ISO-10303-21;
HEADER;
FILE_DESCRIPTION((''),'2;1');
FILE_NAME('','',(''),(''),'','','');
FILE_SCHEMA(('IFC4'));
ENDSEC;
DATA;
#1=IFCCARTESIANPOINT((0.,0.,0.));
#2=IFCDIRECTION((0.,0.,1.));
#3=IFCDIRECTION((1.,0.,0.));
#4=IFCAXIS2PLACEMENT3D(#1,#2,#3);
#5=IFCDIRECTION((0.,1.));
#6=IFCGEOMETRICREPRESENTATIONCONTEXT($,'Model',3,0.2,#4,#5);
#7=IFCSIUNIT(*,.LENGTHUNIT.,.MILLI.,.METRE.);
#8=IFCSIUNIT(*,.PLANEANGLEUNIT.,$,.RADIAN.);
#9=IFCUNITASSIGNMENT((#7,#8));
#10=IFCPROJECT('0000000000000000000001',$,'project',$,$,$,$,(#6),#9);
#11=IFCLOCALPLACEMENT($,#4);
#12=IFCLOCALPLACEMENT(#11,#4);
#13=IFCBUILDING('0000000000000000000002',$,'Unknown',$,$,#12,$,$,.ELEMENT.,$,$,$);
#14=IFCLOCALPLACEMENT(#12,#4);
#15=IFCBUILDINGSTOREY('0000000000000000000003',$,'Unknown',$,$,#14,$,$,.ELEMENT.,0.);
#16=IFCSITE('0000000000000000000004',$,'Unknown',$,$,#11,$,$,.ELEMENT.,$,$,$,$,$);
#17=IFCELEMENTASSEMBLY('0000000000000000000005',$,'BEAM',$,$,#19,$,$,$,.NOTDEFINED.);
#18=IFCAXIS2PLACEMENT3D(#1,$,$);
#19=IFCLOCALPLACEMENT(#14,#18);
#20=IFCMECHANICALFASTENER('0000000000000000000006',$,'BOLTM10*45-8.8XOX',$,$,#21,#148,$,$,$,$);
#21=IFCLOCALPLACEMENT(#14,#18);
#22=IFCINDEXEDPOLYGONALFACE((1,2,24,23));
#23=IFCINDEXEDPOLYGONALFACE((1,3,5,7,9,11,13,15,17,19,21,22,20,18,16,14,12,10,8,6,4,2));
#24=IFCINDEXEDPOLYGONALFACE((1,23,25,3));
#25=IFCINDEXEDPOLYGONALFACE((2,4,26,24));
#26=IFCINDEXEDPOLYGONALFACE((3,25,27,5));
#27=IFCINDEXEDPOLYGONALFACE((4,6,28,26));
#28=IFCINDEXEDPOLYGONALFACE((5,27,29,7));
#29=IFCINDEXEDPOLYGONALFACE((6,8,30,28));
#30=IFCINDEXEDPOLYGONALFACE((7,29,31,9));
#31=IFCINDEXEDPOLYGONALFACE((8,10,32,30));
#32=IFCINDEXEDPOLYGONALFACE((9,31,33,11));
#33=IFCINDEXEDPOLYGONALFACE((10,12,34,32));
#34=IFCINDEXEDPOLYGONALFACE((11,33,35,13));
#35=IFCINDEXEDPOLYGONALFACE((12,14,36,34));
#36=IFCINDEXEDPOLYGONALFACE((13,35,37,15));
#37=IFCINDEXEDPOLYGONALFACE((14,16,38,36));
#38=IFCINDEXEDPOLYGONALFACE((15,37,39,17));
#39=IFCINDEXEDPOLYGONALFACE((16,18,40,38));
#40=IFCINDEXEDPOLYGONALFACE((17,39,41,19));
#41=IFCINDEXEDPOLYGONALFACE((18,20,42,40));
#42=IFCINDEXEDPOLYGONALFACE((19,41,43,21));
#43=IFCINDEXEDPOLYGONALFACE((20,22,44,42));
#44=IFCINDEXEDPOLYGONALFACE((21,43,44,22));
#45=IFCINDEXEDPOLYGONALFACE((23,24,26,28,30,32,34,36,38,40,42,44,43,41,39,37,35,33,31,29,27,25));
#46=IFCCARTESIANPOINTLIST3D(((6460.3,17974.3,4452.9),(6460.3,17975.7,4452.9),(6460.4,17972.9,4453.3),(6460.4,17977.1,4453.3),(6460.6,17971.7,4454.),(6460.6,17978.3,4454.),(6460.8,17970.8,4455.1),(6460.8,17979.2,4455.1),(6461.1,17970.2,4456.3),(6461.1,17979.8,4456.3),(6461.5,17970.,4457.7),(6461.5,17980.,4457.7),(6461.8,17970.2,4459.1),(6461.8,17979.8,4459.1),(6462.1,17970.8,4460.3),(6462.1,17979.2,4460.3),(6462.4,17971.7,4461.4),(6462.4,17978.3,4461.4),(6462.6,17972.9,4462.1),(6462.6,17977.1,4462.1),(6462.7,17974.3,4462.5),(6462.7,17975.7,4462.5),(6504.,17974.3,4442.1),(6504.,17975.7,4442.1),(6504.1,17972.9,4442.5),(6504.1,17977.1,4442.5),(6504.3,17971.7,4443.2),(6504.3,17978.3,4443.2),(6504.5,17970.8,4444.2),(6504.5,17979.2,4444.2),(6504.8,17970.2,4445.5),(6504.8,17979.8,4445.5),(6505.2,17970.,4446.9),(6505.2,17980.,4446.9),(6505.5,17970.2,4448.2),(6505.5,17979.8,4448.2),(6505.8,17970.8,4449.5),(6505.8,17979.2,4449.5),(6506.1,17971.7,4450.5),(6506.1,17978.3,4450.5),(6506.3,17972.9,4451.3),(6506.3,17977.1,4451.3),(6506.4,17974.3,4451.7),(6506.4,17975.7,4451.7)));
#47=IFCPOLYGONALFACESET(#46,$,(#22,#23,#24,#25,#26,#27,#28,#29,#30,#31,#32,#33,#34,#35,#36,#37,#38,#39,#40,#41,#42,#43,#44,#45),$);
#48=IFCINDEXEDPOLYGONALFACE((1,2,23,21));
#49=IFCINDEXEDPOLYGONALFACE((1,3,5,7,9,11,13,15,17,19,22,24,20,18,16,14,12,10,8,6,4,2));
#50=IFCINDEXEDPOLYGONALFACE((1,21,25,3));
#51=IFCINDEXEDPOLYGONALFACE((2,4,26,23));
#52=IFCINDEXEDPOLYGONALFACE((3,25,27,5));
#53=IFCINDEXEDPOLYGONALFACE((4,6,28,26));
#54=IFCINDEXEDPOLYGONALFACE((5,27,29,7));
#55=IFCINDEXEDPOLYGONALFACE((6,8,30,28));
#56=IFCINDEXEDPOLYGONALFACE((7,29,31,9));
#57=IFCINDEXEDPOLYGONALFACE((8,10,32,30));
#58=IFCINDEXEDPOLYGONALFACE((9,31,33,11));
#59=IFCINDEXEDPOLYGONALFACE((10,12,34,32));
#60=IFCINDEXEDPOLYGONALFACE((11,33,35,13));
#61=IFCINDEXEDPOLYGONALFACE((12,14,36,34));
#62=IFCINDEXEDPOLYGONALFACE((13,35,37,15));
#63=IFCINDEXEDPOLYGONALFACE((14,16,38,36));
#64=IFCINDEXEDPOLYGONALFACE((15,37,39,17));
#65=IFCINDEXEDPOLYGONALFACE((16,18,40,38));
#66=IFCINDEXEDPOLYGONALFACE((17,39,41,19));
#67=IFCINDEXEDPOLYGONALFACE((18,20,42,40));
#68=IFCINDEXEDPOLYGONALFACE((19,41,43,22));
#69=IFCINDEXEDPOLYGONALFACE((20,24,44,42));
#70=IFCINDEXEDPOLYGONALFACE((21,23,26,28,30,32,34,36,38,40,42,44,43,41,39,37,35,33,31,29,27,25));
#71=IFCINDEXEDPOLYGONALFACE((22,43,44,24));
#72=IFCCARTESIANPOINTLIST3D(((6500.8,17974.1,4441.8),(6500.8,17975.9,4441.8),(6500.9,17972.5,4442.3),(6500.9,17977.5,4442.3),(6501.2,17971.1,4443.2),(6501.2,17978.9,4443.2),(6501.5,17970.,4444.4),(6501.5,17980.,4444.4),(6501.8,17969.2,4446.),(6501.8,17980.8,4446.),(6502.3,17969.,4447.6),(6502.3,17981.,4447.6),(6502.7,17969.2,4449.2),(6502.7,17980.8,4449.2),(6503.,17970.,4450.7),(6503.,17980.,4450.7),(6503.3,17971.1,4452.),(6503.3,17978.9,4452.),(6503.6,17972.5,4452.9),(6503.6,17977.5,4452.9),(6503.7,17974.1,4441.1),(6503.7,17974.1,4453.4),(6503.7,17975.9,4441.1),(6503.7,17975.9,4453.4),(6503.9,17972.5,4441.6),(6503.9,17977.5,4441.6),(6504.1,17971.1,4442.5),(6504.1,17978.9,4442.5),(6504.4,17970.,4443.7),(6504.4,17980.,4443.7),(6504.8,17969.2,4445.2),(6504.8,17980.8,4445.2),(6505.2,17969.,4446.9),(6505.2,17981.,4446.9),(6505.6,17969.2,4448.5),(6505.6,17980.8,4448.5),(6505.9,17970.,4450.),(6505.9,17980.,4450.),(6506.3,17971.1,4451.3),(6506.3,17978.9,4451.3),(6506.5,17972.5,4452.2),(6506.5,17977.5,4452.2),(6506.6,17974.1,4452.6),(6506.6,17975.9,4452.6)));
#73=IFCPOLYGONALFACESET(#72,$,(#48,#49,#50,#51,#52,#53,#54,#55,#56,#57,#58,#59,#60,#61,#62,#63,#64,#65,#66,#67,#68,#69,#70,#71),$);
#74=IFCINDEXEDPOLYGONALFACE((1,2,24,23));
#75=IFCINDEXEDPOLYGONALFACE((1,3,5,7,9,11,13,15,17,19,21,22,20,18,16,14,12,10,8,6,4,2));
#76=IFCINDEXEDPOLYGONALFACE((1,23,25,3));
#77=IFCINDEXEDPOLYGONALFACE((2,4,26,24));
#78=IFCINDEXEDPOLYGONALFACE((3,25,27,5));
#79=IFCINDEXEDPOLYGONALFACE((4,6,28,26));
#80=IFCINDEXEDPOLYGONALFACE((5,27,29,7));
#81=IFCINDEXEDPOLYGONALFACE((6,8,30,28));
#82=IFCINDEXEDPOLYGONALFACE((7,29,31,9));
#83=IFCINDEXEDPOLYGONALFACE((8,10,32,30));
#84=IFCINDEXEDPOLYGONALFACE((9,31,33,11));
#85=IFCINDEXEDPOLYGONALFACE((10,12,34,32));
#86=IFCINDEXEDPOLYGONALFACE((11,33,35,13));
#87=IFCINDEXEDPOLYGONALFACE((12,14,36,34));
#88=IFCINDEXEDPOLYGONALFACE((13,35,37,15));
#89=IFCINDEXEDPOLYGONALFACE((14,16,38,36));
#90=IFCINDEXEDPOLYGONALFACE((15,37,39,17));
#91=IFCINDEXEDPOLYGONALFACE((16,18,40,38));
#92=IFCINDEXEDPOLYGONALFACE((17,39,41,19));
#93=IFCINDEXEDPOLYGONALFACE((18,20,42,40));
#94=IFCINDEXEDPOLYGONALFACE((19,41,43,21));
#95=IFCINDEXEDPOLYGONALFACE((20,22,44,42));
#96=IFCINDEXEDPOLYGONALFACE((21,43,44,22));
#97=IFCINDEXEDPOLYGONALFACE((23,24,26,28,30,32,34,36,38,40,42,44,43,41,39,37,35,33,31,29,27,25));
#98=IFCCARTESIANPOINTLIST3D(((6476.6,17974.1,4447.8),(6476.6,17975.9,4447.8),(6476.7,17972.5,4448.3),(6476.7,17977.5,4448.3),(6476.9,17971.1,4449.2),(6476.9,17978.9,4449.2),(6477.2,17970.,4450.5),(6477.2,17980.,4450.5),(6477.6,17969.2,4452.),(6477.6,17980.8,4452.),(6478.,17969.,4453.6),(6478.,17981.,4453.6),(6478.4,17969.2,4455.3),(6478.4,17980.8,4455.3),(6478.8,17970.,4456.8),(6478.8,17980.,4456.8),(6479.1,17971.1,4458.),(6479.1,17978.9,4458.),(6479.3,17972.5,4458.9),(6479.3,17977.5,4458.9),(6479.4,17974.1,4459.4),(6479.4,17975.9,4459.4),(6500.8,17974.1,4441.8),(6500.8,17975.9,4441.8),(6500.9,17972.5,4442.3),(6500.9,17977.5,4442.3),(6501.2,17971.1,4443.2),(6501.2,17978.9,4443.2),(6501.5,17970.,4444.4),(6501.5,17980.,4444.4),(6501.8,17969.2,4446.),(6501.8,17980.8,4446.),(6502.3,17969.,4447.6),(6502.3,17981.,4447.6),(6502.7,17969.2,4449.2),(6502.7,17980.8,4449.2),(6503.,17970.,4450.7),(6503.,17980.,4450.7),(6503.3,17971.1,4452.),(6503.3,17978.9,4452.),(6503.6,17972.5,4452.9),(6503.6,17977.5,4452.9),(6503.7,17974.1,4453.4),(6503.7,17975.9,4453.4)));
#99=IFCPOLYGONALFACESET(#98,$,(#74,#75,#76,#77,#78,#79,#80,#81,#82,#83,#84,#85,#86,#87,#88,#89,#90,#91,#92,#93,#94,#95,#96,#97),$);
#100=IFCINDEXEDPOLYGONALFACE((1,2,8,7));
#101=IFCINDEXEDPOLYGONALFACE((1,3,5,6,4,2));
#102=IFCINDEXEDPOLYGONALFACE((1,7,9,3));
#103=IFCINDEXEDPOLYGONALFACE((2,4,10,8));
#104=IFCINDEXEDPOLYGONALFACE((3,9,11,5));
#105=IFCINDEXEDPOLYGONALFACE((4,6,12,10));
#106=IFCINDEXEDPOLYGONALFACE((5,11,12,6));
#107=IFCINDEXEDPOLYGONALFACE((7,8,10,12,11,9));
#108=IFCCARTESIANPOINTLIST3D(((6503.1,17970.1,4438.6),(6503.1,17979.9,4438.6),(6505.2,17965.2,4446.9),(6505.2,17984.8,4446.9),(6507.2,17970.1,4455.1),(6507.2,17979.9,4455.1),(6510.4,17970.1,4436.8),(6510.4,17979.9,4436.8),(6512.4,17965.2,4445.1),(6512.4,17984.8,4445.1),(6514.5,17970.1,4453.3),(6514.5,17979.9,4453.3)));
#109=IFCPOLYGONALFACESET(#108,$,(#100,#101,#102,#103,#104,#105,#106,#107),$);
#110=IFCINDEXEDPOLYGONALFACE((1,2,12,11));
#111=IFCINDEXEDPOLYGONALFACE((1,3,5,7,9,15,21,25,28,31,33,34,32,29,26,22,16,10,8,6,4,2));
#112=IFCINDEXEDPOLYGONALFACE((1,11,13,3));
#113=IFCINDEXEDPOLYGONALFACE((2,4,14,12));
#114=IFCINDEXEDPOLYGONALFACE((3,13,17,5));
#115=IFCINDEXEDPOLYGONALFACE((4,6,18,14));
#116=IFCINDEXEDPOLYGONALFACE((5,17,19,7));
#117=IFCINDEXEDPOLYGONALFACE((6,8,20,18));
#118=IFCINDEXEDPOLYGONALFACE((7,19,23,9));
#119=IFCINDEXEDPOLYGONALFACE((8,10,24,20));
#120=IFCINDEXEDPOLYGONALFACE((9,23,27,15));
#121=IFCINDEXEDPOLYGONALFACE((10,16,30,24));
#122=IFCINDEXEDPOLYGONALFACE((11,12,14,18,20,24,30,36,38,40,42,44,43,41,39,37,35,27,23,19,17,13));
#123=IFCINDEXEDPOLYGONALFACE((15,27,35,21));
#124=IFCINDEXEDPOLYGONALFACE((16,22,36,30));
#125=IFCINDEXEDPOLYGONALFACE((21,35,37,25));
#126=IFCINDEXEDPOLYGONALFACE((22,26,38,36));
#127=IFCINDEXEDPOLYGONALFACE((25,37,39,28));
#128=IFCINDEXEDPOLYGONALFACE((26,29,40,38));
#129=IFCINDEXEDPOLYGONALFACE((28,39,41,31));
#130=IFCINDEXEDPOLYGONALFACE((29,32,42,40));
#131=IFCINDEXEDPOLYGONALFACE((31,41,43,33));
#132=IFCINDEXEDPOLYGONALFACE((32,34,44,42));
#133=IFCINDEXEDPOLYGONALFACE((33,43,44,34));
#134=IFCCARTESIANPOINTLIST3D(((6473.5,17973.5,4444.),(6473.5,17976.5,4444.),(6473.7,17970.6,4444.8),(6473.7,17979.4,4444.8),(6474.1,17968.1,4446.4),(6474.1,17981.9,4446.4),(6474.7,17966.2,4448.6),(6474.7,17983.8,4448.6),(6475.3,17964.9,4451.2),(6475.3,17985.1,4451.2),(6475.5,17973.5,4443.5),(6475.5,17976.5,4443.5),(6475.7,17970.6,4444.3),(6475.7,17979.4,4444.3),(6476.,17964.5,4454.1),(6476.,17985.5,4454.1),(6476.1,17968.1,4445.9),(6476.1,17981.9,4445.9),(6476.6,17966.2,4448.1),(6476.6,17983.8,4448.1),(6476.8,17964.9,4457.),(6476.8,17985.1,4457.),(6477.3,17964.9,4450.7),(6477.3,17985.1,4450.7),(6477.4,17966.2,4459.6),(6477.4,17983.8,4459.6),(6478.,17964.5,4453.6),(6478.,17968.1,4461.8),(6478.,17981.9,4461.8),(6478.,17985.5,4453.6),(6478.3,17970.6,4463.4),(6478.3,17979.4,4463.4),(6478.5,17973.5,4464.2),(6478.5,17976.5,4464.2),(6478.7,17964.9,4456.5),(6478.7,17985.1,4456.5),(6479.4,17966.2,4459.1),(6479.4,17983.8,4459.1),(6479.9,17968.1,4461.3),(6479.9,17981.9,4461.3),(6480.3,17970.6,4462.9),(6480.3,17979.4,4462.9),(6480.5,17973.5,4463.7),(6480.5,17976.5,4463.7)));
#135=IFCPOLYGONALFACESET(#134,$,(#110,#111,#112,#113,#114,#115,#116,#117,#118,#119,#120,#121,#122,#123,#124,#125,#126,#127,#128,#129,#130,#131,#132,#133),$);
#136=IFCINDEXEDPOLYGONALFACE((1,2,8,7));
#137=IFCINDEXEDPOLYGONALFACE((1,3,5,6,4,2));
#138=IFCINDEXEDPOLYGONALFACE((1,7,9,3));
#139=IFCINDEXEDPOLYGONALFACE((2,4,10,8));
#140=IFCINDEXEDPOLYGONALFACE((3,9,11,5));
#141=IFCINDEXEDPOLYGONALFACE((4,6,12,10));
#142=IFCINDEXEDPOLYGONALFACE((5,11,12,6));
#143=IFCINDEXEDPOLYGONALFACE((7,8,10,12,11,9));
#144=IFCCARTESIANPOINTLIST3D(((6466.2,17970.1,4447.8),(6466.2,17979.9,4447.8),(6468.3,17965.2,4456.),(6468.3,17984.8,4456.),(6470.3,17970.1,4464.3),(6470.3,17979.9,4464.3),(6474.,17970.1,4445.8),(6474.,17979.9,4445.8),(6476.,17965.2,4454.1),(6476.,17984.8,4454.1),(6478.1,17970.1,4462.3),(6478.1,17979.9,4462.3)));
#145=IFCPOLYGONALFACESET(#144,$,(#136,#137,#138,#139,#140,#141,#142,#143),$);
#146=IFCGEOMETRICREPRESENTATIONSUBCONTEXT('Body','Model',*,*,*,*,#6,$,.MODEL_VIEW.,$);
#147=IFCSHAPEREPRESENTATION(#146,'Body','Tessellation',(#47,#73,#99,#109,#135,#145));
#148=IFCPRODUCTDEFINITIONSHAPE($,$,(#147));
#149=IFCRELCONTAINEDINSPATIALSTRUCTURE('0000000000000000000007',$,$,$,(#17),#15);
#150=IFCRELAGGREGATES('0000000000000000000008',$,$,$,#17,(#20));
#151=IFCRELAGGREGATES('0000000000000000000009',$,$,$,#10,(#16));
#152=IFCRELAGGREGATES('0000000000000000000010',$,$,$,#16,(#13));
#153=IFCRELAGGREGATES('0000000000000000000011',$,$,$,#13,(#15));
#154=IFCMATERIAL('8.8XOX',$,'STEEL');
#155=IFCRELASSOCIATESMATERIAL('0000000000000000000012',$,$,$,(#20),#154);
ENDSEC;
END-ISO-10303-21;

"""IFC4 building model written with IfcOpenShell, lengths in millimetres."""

from ifc_helpers import new_model, si_unit, direction, frame, origin_with_axes, place, context, subcontext, project, spatial, line, arc, indexed_curve, outline, extrude, source, transform, mapped, material, element, aggregate, save


model = new_model("IFC4")

# Units and contexts
model_context = context("Model", 3, precision=0.2, world=origin_with_axes(), true_north=direction((0.0, 1.0)))
body_context = subcontext(model_context, "Body", "Model", "MODEL_VIEW")
ifc_project = project(units=[si_unit("LENGTHUNIT", "METRE", prefix="MILLI"), si_unit("PLANEANGLEUNIT", "RADIAN")], contexts=[model_context])

# Site, building, storey
site_placement = place(None, origin_with_axes())
site = spatial("IfcSite", under=ifc_project, at=site_placement, Name="Unknown", CompositionType="ELEMENT")
building_placement = place(site_placement, origin_with_axes())
building = spatial("IfcBuilding", under=site, at=building_placement, Name="Unknown", CompositionType="ELEMENT")
storey_placement = place(building_placement, origin_with_axes())
storey = spatial("IfcBuildingStorey", under=building, at=storey_placement, Name="Unknown", CompositionType="ELEMENT", Elevation=0.0)

# Shared definitions
ifc_material_1 = material(Name="8.8XOX", Category="STEEL")

# Element assembly, mechanical fastener
shared_shape_1 = source(origin_with_axes(), body_context, "Body", "SweptSolid", [
    extrude(outline(indexed_curve([(5.0, 0.0), (0.0, 5.0), (-5.0, 0.0), (0.0, -5.0)], segments=[arc(1, 2, 3), arc(3, 4, 1)])), frame((0.0, 0.0, 3.8), z_axis=(0.0, 0.0, -1.0), x_axis=(0.0, 1.0, 0.0)), (0.0, 0.0, 1.0), 45.0),
    extrude(outline(indexed_curve([(6.0, 0.0), (0.0, 6.0), (-6.0, 0.0), (0.0, -6.0)], segments=[arc(1, 2, 3), arc(3, 4, 1)])), frame((0.0, 0.0, 3.8), z_axis=(0.0, 0.0, -1.0), x_axis=(0.0, 1.0, 0.0)), (0.0, 0.0, 1.0), 3.0),
    extrude(outline(indexed_curve([(6.0, 0.0), (0.0, 6.0), (-6.0, 0.0), (0.0, -6.0)], segments=[arc(1, 2, 3), arc(3, 4, 1)])), frame((0.0, 0.0, 0.8), z_axis=(0.0, 0.0, -1.0), x_axis=(0.0, 1.0, 0.0)), (0.0, 0.0, 1.0), 25.0),
    extrude(outline(indexed_curve([(9.8, 0.0), (4.9, 8.5), (-4.9, 8.5), (-9.8, 0.0), (-4.9, -8.5), (4.9, -8.5)], segments=[line(1, 2, 3, 4, 5, 6, 1)])), frame((0.0, 0.0, 11.2), z_axis=(0.0, 0.0, -1.0), x_axis=(0.0, 1.0, 0.0)), (0.0, 0.0, 1.0), 7.5),
    extrude(outline(indexed_curve([(10.5, 0.0), (0.0, 10.5), (-10.5, 0.0), (0.0, -10.5)], segments=[arc(1, 2, 3), arc(3, 4, 1)])), frame((0.0, 0.0, -24.2), z_axis=(0.0, 0.0, -1.0), x_axis=(0.0, 1.0, 0.0)), (0.0, 0.0, 1.0), 2.0),
    extrude(outline(indexed_curve([(9.8, 0.0), (4.9, 8.5), (-4.9, 8.5), (-9.8, 0.0), (-4.9, -8.5), (4.9, -8.5)], segments=[line(1, 2, 3, 4, 5, 6, 1)])), frame((0.0, 0.0, -26.2), z_axis=(0.0, 0.0, -1.0), x_axis=(0.0, 1.0, 0.0)), (0.0, 0.0, 1.0), 8.0),
])
assembly_1_placement = place(storey_placement, frame((6491.3, 12000.0, 4455.5), z_axis=(0.970613, 0.0, -0.240648), x_axis=(0.0, 1.0, 0.0)))
assembly_1 = element("IfcElementAssembly", 1, at=assembly_1_placement, inside=storey, Name="BEAM", PredefinedType="NOTDEFINED")
mechanical_fastener_1_placement = place(assembly_1_placement, frame((5975.0, -5.0, 11.8), z_axis=(0.0, 0.0, 1.0), x_axis=(0.0, 1.0, 0.0)))
mechanical_fastener_1 = element("IfcMechanicalFastener", 2, at=mechanical_fastener_1_placement, material=ifc_material_1, Name="BOLTM10*45-8.8XOX", context=body_context, shape_type="MappedRepresentation", body=[
    mapped(shared_shape_1, transform((0.0, 0.0, 0.0))),
])
aggregate(assembly_1, [mechanical_fastener_1])

save(model, "model.ifc")
